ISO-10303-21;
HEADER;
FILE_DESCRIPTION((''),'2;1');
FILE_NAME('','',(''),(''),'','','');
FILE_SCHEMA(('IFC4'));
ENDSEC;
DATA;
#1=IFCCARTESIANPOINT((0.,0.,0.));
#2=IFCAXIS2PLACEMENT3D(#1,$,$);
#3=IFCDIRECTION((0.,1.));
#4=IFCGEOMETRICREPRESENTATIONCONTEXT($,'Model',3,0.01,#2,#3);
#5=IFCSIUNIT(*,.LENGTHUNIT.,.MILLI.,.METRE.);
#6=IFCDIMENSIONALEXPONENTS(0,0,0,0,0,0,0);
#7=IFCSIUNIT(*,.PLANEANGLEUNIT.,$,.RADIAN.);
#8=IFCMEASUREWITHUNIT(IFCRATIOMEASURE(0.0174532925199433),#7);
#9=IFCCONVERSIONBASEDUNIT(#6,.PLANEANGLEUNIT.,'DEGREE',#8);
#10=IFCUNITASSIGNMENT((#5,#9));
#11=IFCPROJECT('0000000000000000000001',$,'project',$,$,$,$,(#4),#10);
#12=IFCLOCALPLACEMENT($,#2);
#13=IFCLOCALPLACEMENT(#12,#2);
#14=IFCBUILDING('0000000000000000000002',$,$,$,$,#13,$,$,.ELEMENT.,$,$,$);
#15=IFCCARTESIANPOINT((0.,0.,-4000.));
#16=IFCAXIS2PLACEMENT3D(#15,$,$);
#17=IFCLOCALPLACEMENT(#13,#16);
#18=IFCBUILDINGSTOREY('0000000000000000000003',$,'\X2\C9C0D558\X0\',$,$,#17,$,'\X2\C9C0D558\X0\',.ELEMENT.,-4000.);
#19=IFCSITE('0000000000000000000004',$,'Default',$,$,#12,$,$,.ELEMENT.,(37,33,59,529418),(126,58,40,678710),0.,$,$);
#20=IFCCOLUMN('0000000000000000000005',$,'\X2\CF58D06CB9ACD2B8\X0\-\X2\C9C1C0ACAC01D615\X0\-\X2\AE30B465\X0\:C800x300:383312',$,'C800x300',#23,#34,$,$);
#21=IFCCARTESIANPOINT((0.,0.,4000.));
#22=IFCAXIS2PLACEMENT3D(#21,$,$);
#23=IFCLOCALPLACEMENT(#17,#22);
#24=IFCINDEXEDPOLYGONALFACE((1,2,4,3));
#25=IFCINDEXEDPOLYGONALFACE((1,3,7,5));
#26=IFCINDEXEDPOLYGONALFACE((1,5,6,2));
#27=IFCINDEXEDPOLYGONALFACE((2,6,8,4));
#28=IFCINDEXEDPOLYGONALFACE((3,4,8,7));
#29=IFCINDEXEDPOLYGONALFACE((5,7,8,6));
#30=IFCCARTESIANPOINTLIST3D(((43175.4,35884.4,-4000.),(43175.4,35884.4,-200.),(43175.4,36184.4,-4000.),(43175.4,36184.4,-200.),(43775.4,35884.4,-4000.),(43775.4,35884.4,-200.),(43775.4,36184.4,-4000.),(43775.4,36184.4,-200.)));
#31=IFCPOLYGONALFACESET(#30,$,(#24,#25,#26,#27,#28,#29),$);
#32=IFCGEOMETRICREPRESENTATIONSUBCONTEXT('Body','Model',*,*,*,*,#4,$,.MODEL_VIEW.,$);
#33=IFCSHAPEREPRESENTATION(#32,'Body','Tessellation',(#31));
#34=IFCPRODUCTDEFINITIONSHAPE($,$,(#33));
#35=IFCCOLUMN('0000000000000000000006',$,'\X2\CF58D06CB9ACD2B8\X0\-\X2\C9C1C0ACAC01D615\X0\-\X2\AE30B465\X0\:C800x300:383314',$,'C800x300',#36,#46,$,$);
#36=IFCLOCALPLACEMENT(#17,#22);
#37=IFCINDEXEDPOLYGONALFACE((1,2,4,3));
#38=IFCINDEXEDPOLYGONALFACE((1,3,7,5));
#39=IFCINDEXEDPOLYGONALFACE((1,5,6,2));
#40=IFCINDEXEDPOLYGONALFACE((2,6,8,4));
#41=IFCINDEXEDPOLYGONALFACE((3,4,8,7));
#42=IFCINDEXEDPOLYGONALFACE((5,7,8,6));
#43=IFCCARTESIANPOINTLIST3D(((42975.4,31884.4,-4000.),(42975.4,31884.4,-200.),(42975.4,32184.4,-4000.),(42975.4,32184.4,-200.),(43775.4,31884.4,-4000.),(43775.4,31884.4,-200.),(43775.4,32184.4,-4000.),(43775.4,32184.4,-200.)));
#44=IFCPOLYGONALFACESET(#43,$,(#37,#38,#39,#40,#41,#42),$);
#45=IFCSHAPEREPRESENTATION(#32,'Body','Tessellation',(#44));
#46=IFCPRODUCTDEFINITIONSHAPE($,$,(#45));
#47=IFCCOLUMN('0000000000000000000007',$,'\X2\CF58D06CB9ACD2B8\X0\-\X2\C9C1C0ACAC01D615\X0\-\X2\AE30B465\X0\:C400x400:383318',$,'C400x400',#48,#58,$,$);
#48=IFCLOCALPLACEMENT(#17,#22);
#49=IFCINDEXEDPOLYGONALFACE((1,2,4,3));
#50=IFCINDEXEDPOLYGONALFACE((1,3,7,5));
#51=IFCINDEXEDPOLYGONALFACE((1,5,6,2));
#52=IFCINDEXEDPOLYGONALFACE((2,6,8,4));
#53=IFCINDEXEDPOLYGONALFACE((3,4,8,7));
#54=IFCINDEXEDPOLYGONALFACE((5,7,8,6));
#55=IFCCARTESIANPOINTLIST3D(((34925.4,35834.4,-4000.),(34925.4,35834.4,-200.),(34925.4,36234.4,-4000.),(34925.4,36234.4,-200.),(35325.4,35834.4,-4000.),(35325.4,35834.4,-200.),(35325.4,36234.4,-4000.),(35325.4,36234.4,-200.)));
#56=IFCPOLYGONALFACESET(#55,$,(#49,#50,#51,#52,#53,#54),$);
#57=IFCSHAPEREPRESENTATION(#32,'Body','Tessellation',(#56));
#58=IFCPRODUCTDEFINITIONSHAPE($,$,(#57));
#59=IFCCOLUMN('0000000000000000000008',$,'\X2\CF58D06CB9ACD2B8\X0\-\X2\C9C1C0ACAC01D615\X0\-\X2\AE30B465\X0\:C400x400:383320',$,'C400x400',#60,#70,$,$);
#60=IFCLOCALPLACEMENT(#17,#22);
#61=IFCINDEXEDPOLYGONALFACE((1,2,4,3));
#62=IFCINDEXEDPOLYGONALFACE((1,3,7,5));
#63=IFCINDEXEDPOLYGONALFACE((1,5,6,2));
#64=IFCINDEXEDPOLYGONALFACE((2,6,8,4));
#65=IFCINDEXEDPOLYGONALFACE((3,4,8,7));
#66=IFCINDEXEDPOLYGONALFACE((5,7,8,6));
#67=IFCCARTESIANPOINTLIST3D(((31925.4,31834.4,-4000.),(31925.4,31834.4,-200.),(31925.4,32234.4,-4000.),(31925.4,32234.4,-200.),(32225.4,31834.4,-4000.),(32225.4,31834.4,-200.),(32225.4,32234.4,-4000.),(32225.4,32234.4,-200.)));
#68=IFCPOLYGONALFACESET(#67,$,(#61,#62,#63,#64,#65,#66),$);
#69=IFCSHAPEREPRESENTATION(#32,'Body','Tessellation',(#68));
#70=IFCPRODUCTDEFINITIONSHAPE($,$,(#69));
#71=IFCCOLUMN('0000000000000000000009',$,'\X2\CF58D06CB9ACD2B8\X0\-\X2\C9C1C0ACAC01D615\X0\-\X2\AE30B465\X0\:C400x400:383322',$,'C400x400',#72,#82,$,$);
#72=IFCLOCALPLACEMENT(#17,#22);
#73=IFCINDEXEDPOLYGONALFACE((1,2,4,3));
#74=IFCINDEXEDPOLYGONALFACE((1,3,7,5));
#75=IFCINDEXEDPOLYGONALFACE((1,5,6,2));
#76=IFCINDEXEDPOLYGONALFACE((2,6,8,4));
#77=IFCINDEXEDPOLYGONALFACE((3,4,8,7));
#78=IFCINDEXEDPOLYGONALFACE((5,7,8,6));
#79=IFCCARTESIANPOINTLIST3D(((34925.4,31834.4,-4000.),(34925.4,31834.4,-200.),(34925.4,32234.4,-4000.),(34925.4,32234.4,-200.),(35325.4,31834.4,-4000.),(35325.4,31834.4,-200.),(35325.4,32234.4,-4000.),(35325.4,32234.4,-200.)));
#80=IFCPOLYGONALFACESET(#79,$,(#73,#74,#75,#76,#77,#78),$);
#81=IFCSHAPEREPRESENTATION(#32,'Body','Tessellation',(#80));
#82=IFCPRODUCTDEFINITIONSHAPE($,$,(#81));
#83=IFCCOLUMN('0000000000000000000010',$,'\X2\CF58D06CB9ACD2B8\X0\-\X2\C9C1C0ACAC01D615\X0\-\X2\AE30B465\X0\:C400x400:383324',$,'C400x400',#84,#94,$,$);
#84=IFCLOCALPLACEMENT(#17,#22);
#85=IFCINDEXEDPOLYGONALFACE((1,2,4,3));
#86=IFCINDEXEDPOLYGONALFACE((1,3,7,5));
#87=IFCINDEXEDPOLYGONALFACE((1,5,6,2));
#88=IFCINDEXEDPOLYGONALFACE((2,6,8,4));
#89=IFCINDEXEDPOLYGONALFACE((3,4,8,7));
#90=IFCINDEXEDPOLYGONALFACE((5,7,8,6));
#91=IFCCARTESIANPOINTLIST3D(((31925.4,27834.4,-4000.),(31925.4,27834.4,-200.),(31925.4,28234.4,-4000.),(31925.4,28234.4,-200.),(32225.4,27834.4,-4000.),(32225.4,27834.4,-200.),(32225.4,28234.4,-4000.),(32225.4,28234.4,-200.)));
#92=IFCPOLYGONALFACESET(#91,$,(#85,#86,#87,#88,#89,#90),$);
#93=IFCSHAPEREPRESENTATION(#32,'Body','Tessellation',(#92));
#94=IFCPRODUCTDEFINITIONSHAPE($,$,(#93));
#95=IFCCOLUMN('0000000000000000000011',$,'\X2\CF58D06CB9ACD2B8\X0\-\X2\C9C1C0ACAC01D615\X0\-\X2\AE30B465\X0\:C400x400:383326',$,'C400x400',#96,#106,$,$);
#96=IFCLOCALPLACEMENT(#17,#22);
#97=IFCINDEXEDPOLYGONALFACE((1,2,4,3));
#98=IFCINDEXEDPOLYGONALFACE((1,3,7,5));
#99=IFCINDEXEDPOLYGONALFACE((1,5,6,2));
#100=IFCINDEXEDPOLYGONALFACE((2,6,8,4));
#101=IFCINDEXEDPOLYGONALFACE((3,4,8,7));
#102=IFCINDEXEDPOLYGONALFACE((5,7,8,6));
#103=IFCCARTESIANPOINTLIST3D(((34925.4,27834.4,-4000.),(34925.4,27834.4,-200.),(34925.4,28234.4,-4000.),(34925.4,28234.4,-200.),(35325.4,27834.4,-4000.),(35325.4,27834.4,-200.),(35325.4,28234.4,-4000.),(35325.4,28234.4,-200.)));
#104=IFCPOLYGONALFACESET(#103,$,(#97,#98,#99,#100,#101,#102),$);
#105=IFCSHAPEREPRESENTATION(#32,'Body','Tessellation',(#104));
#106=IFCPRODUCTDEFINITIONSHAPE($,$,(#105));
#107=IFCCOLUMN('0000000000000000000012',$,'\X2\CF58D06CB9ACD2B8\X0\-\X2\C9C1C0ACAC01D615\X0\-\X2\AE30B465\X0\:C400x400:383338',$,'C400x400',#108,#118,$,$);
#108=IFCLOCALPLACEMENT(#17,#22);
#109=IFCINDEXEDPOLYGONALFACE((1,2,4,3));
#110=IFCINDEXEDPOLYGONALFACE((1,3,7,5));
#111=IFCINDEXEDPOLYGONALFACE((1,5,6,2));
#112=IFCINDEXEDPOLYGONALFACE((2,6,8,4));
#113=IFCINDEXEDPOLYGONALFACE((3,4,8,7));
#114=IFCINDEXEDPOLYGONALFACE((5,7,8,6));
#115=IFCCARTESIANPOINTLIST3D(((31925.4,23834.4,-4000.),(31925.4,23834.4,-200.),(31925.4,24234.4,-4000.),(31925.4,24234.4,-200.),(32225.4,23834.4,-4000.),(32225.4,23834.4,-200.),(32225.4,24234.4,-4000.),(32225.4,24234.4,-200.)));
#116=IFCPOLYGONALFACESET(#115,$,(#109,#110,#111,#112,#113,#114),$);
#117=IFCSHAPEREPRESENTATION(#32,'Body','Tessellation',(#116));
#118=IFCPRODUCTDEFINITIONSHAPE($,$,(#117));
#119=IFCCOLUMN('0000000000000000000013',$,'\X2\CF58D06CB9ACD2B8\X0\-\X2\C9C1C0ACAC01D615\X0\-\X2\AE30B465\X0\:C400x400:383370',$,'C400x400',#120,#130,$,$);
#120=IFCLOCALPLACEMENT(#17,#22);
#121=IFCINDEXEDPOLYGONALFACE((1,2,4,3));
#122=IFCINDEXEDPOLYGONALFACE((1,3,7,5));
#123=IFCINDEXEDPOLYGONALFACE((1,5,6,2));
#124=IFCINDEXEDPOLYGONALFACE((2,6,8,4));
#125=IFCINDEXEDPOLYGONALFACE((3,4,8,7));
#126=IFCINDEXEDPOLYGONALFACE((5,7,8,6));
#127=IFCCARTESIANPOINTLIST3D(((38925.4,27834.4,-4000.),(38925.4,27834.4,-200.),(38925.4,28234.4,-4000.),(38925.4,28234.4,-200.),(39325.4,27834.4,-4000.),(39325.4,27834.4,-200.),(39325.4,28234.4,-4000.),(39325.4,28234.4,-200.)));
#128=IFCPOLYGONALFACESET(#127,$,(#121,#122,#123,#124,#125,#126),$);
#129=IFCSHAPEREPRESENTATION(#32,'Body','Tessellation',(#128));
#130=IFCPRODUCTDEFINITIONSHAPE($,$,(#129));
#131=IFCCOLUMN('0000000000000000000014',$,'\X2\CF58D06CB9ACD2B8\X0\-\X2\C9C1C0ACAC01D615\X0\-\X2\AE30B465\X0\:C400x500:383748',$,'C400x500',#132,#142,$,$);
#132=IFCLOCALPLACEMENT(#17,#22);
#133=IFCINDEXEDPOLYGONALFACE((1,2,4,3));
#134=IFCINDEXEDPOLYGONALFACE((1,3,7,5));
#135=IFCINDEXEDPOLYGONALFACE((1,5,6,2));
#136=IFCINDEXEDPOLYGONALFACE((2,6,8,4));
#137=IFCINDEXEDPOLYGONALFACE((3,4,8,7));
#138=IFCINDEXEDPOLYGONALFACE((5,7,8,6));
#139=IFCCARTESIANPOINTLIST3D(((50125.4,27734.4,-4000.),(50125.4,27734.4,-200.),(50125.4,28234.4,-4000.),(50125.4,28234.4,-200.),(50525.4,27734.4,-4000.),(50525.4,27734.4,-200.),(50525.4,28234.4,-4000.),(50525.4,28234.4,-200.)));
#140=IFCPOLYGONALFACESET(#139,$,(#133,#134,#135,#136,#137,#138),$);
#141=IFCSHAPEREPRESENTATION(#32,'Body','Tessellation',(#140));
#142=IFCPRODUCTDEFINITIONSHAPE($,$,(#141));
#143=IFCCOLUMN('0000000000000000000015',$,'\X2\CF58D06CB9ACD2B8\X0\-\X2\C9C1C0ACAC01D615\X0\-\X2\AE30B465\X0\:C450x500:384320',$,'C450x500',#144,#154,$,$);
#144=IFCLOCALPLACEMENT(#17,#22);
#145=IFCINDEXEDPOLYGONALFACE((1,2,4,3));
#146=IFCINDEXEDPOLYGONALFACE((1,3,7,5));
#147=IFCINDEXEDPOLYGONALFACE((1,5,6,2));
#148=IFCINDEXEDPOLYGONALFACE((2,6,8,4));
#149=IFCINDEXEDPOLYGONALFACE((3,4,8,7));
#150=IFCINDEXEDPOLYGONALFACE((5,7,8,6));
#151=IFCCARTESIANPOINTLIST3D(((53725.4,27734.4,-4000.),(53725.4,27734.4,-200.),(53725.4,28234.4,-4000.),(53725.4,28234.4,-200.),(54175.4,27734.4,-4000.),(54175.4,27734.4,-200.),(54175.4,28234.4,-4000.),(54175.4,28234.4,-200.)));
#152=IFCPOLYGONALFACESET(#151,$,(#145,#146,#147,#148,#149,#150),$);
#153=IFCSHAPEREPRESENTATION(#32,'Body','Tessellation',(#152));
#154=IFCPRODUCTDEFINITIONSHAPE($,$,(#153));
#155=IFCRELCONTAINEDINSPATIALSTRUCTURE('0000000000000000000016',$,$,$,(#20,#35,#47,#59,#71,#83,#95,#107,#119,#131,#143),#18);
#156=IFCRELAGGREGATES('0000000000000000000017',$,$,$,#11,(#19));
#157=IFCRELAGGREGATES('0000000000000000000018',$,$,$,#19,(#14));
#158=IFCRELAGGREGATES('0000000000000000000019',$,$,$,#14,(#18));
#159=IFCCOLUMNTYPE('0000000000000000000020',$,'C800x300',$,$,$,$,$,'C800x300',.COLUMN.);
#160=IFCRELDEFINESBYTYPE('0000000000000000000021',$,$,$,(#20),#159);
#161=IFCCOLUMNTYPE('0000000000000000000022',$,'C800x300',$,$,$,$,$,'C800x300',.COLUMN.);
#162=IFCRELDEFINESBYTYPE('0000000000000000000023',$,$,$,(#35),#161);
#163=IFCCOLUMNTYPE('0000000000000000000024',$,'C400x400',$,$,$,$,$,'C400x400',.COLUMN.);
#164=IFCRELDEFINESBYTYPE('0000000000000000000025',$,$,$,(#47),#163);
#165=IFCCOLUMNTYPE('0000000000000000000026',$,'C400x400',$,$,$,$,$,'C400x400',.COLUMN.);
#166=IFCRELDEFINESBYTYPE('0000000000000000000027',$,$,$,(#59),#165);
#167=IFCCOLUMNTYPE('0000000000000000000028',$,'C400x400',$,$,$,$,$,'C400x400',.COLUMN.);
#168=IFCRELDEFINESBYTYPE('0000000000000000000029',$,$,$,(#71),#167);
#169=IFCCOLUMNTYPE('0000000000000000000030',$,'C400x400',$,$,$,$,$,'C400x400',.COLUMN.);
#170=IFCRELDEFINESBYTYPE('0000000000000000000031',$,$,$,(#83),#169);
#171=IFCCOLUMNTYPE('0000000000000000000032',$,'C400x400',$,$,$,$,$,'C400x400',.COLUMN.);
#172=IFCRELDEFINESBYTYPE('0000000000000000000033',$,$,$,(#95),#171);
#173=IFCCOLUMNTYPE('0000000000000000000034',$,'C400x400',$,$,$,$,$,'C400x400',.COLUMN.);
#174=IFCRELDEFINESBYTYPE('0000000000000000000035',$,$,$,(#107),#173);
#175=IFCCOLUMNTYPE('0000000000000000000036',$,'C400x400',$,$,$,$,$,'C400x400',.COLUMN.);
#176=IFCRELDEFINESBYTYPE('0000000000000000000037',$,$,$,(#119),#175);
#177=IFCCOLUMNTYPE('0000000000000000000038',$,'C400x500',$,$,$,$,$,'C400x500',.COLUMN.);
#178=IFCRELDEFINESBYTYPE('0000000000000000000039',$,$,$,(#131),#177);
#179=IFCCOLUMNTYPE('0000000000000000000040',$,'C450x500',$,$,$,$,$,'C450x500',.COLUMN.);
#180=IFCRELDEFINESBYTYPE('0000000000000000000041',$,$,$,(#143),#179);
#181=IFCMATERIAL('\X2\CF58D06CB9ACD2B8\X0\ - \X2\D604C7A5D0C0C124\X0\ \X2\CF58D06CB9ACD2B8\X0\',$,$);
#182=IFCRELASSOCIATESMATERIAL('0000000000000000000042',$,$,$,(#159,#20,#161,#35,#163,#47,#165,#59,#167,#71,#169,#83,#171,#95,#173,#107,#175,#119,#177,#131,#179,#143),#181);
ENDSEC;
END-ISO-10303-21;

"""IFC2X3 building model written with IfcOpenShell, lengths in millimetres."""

from ifc_helpers import new_model, entity, si_unit, converted_unit, direction, frame, frame_2d, origin, origin_2d_with_axis, place, context, subcontext, project, spatial, rectangle, extrude, source, transform, mapped, material, type_object, type_shapes, element, save


model = new_model("IFC2X3")

# Units and contexts
model_context = context("Model", 3, precision=0.01, world=origin(), true_north=direction((0.0, 1.0)))
body_context = subcontext(model_context, "Body", "Model", "MODEL_VIEW")
ifc_project = project(units=[si_unit("LENGTHUNIT", "METRE", prefix="MILLI"), converted_unit("PLANEANGLEUNIT", "DEGREE", entity("IfcRatioMeasure", 0.0174532925199433), si_unit("PLANEANGLEUNIT", "RADIAN"), dimensions=[0, 0, 0, 0, 0, 0, 0])], contexts=[model_context])

# Site, building, storey
site_placement = place(None, origin())
site = spatial("IfcSite", under=ifc_project, at=site_placement, Name="Default", CompositionType="ELEMENT", RefLatitude=(37, 33, 59, 529418), RefLongitude=(126, 58, 40, 678710), RefElevation=0.0)
building_placement = place(site_placement, origin())
building = spatial("IfcBuilding", under=site, at=building_placement, CompositionType="ELEMENT")
storey_placement = place(building_placement, frame((0.0, 0.0, -4000.0)))
storey = spatial("IfcBuildingStorey", under=building, at=storey_placement, Name="지하", LongName="지하", CompositionType="ELEMENT", Elevation=-4000.0)

# Columns
ifc_material_1 = material(Name="콘크리트 - 현장타설 콘크리트")
column_type_1 = type_object("IfcColumnType", Name="C800x300", ElementType="C800x300", PredefinedType="COLUMN", material=ifc_material_1)
shared_shape_1 = source(origin(), body_context, "Body", "SweptSolid", [
    extrude(rectangle(XDim=300.0, YDim=600.0, at=frame_2d((0.0, 0.0), x_axis=(1.0, 0.0))), frame((43475.4, 36034.4, -4000.0), z_axis=(0.0, 0.0, 1.0), x_axis=(0.0, -1.0, 0.0)), (0.0, 0.0, 1.0), 3800.0),
])
type_shapes(column_type_1, [shared_shape_1])
column_1_placement = place(storey_placement, frame((0.0, 0.0, 4000.0)))
element("IfcColumn", 1, at=column_1_placement, inside=storey, type_object=column_type_1, material=ifc_material_1, Name="콘크리트-직사각형-기둥:C800x300:383312", ObjectType="C800x300", context=body_context, shape_type="MappedRepresentation", body=[
    mapped(shared_shape_1, transform((0.0, 0.0, 0.0), scale=1.0)),
])
column_type_2 = type_object("IfcColumnType", Name="C800x300", ElementType="C800x300", PredefinedType="COLUMN", material=ifc_material_1)
shared_shape_2 = source(origin(), body_context, "Body", "SweptSolid", [
    extrude(rectangle(XDim=300.0, YDim=800.0, at=frame_2d((0.0, 0.0), x_axis=(1.0, 0.0))), frame((43375.4, 32034.4, -4000.0), z_axis=(0.0, 0.0, 1.0), x_axis=(0.0, -1.0, 0.0)), (0.0, 0.0, 1.0), 3800.0),
])
type_shapes(column_type_2, [shared_shape_2])
column_2_placement = place(storey_placement, frame((0.0, 0.0, 4000.0)))
element("IfcColumn", 2, at=column_2_placement, inside=storey, type_object=column_type_2, material=ifc_material_1, Name="콘크리트-직사각형-기둥:C800x300:383314", ObjectType="C800x300", context=body_context, shape_type="MappedRepresentation", body=[
    mapped(shared_shape_2, transform((0.0, 0.0, 0.0), scale=1.0)),
])
column_type_3 = type_object("IfcColumnType", Name="C400x400", ElementType="C400x400", PredefinedType="COLUMN", material=ifc_material_1)
shared_shape_3 = source(origin(), body_context, "Body", "SweptSolid", [
    extrude(rectangle(XDim=400.0, YDim=400.0, at=frame_2d((0.0, 0.0), x_axis=(1.0, 0.0))), frame((35125.4, 36034.4, -4000.0), z_axis=(0.0, 0.0, 1.0), x_axis=(0.0, -1.0, 0.0)), (0.0, 0.0, 1.0), 3800.0),
])
type_shapes(column_type_3, [shared_shape_3])
column_3_placement = place(storey_placement, frame((0.0, 0.0, 4000.0)))
element("IfcColumn", 3, at=column_3_placement, inside=storey, type_object=column_type_3, material=ifc_material_1, Name="콘크리트-직사각형-기둥:C400x400:383318", ObjectType="C400x400", context=body_context, shape_type="MappedRepresentation", body=[
    mapped(shared_shape_3, transform((0.0, 0.0, 0.0), scale=1.0)),
])
column_type_4 = type_object("IfcColumnType", Name="C400x400", ElementType="C400x400", PredefinedType="COLUMN", material=ifc_material_1)
shared_shape_4 = source(origin(), body_context, "Body", "SweptSolid", [
    extrude(rectangle(XDim=400.0, YDim=300.0, at=frame_2d((0.0, 0.0), x_axis=(1.0, 0.0))), frame((32075.4, 32034.4, -4000.0), z_axis=(0.0, 0.0, 1.0), x_axis=(0.0, -1.0, 0.0)), (0.0, 0.0, 1.0), 3800.0),
])
type_shapes(column_type_4, [shared_shape_4])
column_4_placement = place(storey_placement, frame((0.0, 0.0, 4000.0)))
element("IfcColumn", 4, at=column_4_placement, inside=storey, type_object=column_type_4, material=ifc_material_1, Name="콘크리트-직사각형-기둥:C400x400:383320", ObjectType="C400x400", context=body_context, shape_type="MappedRepresentation", body=[
    mapped(shared_shape_4, transform((0.0, 0.0, 0.0), scale=1.0)),
])
column_type_5 = type_object("IfcColumnType", Name="C400x400", ElementType="C400x400", PredefinedType="COLUMN", material=ifc_material_1)
shared_shape_5 = source(origin(), body_context, "Body", "SweptSolid", [
    extrude(rectangle(XDim=400.0, YDim=400.0, at=frame_2d((0.0, 0.0), x_axis=(1.0, 0.0))), frame((35125.4, 32034.4, -4000.0), z_axis=(0.0, 0.0, 1.0), x_axis=(0.0, -1.0, 0.0)), (0.0, 0.0, 1.0), 3800.0),
])
type_shapes(column_type_5, [shared_shape_5])
column_5_placement = place(storey_placement, frame((0.0, 0.0, 4000.0)))
element("IfcColumn", 5, at=column_5_placement, inside=storey, type_object=column_type_5, material=ifc_material_1, Name="콘크리트-직사각형-기둥:C400x400:383322", ObjectType="C400x400", context=body_context, shape_type="MappedRepresentation", body=[
    mapped(shared_shape_5, transform((0.0, 0.0, 0.0), scale=1.0)),
])
column_type_6 = type_object("IfcColumnType", Name="C400x400", ElementType="C400x400", PredefinedType="COLUMN", material=ifc_material_1)
shared_shape_6 = source(origin(), body_context, "Body", "SweptSolid", [
    extrude(rectangle(XDim=400.0, YDim=300.0, at=frame_2d((0.0, 0.0), x_axis=(1.0, 0.0))), frame((32075.4, 28034.4, -4000.0), z_axis=(0.0, 0.0, 1.0), x_axis=(0.0, -1.0, 0.0)), (0.0, 0.0, 1.0), 3800.0),
])
type_shapes(column_type_6, [shared_shape_6])
column_6_placement = place(storey_placement, frame((0.0, 0.0, 4000.0)))
element("IfcColumn", 6, at=column_6_placement, inside=storey, type_object=column_type_6, material=ifc_material_1, Name="콘크리트-직사각형-기둥:C400x400:383324", ObjectType="C400x400", context=body_context, shape_type="MappedRepresentation", body=[
    mapped(shared_shape_6, transform((0.0, 0.0, 0.0), scale=1.0)),
])
column_type_7 = type_object("IfcColumnType", Name="C400x400", ElementType="C400x400", PredefinedType="COLUMN", material=ifc_material_1)
shared_shape_7 = source(origin(), body_context, "Body", "SweptSolid", [
    extrude(rectangle(XDim=400.0, YDim=400.0, at=frame_2d((0.0, 0.0), x_axis=(1.0, 0.0))), frame((35125.4, 28034.4, -4000.0), z_axis=(0.0, 0.0, 1.0), x_axis=(0.0, -1.0, 0.0)), (0.0, 0.0, 1.0), 3800.0),
])
type_shapes(column_type_7, [shared_shape_7])
column_7_placement = place(storey_placement, frame((0.0, 0.0, 4000.0)))
element("IfcColumn", 7, at=column_7_placement, inside=storey, type_object=column_type_7, material=ifc_material_1, Name="콘크리트-직사각형-기둥:C400x400:383326", ObjectType="C400x400", context=body_context, shape_type="MappedRepresentation", body=[
    mapped(shared_shape_7, transform((0.0, 0.0, 0.0), scale=1.0)),
])
column_type_8 = type_object("IfcColumnType", Name="C400x400", ElementType="C400x400", PredefinedType="COLUMN", material=ifc_material_1)
shared_shape_8 = source(origin(), body_context, "Body", "SweptSolid", [
    extrude(rectangle(XDim=400.0, YDim=300.0, at=frame_2d((0.0, 0.0), x_axis=(1.0, 0.0))), frame((32075.4, 24034.4, -4000.0), z_axis=(0.0, 0.0, 1.0), x_axis=(0.0, -1.0, 0.0)), (0.0, 0.0, 1.0), 3800.0),
])
type_shapes(column_type_8, [shared_shape_8])
column_8_placement = place(storey_placement, frame((0.0, 0.0, 4000.0)))
element("IfcColumn", 8, at=column_8_placement, inside=storey, type_object=column_type_8, material=ifc_material_1, Name="콘크리트-직사각형-기둥:C400x400:383338", ObjectType="C400x400", context=body_context, shape_type="MappedRepresentation", body=[
    mapped(shared_shape_8, transform((0.0, 0.0, 0.0), scale=1.0)),
])
column_type_9 = type_object("IfcColumnType", Name="C400x400", ElementType="C400x400", PredefinedType="COLUMN", material=ifc_material_1)
shared_shape_9 = source(origin(), body_context, "Body", "SweptSolid", [
    extrude(rectangle(XDim=400.0, YDim=400.0, at=frame_2d((0.0, 0.0), x_axis=(1.0, 0.0))), frame((39125.4, 28034.4, -4000.0), z_axis=(0.0, 0.0, 1.0), x_axis=(0.0, -1.0, 0.0)), (0.0, 0.0, 1.0), 3800.0),
])
type_shapes(column_type_9, [shared_shape_9])
column_9_placement = place(storey_placement, frame((0.0, 0.0, 4000.0)))
element("IfcColumn", 9, at=column_9_placement, inside=storey, type_object=column_type_9, material=ifc_material_1, Name="콘크리트-직사각형-기둥:C400x400:383370", ObjectType="C400x400", context=body_context, shape_type="MappedRepresentation", body=[
    mapped(shared_shape_9, transform((0.0, 0.0, 0.0), scale=1.0)),
])
column_type_10 = type_object("IfcColumnType", Name="C400x500", ElementType="C400x500", PredefinedType="COLUMN", material=ifc_material_1)
shared_shape_10 = source(origin(), body_context, "Body", "SweptSolid", [
    extrude(rectangle(XDim=500.0, YDim=400.0, at=origin_2d_with_axis()), frame((50325.4, 27984.4, -4000.0), z_axis=(0.0, 0.0, 1.0), x_axis=(0.0, -1.0, 0.0)), (0.0, 0.0, 1.0), 3800.0),
])
type_shapes(column_type_10, [shared_shape_10])
column_10_placement = place(storey_placement, frame((0.0, 0.0, 4000.0)))
element("IfcColumn", 10, at=column_10_placement, inside=storey, type_object=column_type_10, material=ifc_material_1, Name="콘크리트-직사각형-기둥:C400x500:383748", ObjectType="C400x500", context=body_context, shape_type="MappedRepresentation", body=[
    mapped(shared_shape_10, transform((0.0, 0.0, 0.0), scale=1.0)),
])
column_type_11 = type_object("IfcColumnType", Name="C450x500", ElementType="C450x500", PredefinedType="COLUMN", material=ifc_material_1)
shared_shape_11 = source(origin(), body_context, "Body", "SweptSolid", [
    extrude(rectangle(XDim=500.0, YDim=450.0, at=origin_2d_with_axis()), frame((53950.4, 27984.4, -4000.0), z_axis=(0.0, 0.0, 1.0), x_axis=(0.0, -1.0, 0.0)), (0.0, 0.0, 1.0), 3800.0),
])
type_shapes(column_type_11, [shared_shape_11])
column_11_placement = place(storey_placement, frame((0.0, 0.0, 4000.0)))
element("IfcColumn", 11, at=column_11_placement, inside=storey, type_object=column_type_11, material=ifc_material_1, Name="콘크리트-직사각형-기둥:C450x500:384320", ObjectType="C450x500", context=body_context, shape_type="MappedRepresentation", body=[
    mapped(shared_shape_11, transform((0.0, 0.0, 0.0), scale=1.0)),
])

save(model, "model.ifc")
